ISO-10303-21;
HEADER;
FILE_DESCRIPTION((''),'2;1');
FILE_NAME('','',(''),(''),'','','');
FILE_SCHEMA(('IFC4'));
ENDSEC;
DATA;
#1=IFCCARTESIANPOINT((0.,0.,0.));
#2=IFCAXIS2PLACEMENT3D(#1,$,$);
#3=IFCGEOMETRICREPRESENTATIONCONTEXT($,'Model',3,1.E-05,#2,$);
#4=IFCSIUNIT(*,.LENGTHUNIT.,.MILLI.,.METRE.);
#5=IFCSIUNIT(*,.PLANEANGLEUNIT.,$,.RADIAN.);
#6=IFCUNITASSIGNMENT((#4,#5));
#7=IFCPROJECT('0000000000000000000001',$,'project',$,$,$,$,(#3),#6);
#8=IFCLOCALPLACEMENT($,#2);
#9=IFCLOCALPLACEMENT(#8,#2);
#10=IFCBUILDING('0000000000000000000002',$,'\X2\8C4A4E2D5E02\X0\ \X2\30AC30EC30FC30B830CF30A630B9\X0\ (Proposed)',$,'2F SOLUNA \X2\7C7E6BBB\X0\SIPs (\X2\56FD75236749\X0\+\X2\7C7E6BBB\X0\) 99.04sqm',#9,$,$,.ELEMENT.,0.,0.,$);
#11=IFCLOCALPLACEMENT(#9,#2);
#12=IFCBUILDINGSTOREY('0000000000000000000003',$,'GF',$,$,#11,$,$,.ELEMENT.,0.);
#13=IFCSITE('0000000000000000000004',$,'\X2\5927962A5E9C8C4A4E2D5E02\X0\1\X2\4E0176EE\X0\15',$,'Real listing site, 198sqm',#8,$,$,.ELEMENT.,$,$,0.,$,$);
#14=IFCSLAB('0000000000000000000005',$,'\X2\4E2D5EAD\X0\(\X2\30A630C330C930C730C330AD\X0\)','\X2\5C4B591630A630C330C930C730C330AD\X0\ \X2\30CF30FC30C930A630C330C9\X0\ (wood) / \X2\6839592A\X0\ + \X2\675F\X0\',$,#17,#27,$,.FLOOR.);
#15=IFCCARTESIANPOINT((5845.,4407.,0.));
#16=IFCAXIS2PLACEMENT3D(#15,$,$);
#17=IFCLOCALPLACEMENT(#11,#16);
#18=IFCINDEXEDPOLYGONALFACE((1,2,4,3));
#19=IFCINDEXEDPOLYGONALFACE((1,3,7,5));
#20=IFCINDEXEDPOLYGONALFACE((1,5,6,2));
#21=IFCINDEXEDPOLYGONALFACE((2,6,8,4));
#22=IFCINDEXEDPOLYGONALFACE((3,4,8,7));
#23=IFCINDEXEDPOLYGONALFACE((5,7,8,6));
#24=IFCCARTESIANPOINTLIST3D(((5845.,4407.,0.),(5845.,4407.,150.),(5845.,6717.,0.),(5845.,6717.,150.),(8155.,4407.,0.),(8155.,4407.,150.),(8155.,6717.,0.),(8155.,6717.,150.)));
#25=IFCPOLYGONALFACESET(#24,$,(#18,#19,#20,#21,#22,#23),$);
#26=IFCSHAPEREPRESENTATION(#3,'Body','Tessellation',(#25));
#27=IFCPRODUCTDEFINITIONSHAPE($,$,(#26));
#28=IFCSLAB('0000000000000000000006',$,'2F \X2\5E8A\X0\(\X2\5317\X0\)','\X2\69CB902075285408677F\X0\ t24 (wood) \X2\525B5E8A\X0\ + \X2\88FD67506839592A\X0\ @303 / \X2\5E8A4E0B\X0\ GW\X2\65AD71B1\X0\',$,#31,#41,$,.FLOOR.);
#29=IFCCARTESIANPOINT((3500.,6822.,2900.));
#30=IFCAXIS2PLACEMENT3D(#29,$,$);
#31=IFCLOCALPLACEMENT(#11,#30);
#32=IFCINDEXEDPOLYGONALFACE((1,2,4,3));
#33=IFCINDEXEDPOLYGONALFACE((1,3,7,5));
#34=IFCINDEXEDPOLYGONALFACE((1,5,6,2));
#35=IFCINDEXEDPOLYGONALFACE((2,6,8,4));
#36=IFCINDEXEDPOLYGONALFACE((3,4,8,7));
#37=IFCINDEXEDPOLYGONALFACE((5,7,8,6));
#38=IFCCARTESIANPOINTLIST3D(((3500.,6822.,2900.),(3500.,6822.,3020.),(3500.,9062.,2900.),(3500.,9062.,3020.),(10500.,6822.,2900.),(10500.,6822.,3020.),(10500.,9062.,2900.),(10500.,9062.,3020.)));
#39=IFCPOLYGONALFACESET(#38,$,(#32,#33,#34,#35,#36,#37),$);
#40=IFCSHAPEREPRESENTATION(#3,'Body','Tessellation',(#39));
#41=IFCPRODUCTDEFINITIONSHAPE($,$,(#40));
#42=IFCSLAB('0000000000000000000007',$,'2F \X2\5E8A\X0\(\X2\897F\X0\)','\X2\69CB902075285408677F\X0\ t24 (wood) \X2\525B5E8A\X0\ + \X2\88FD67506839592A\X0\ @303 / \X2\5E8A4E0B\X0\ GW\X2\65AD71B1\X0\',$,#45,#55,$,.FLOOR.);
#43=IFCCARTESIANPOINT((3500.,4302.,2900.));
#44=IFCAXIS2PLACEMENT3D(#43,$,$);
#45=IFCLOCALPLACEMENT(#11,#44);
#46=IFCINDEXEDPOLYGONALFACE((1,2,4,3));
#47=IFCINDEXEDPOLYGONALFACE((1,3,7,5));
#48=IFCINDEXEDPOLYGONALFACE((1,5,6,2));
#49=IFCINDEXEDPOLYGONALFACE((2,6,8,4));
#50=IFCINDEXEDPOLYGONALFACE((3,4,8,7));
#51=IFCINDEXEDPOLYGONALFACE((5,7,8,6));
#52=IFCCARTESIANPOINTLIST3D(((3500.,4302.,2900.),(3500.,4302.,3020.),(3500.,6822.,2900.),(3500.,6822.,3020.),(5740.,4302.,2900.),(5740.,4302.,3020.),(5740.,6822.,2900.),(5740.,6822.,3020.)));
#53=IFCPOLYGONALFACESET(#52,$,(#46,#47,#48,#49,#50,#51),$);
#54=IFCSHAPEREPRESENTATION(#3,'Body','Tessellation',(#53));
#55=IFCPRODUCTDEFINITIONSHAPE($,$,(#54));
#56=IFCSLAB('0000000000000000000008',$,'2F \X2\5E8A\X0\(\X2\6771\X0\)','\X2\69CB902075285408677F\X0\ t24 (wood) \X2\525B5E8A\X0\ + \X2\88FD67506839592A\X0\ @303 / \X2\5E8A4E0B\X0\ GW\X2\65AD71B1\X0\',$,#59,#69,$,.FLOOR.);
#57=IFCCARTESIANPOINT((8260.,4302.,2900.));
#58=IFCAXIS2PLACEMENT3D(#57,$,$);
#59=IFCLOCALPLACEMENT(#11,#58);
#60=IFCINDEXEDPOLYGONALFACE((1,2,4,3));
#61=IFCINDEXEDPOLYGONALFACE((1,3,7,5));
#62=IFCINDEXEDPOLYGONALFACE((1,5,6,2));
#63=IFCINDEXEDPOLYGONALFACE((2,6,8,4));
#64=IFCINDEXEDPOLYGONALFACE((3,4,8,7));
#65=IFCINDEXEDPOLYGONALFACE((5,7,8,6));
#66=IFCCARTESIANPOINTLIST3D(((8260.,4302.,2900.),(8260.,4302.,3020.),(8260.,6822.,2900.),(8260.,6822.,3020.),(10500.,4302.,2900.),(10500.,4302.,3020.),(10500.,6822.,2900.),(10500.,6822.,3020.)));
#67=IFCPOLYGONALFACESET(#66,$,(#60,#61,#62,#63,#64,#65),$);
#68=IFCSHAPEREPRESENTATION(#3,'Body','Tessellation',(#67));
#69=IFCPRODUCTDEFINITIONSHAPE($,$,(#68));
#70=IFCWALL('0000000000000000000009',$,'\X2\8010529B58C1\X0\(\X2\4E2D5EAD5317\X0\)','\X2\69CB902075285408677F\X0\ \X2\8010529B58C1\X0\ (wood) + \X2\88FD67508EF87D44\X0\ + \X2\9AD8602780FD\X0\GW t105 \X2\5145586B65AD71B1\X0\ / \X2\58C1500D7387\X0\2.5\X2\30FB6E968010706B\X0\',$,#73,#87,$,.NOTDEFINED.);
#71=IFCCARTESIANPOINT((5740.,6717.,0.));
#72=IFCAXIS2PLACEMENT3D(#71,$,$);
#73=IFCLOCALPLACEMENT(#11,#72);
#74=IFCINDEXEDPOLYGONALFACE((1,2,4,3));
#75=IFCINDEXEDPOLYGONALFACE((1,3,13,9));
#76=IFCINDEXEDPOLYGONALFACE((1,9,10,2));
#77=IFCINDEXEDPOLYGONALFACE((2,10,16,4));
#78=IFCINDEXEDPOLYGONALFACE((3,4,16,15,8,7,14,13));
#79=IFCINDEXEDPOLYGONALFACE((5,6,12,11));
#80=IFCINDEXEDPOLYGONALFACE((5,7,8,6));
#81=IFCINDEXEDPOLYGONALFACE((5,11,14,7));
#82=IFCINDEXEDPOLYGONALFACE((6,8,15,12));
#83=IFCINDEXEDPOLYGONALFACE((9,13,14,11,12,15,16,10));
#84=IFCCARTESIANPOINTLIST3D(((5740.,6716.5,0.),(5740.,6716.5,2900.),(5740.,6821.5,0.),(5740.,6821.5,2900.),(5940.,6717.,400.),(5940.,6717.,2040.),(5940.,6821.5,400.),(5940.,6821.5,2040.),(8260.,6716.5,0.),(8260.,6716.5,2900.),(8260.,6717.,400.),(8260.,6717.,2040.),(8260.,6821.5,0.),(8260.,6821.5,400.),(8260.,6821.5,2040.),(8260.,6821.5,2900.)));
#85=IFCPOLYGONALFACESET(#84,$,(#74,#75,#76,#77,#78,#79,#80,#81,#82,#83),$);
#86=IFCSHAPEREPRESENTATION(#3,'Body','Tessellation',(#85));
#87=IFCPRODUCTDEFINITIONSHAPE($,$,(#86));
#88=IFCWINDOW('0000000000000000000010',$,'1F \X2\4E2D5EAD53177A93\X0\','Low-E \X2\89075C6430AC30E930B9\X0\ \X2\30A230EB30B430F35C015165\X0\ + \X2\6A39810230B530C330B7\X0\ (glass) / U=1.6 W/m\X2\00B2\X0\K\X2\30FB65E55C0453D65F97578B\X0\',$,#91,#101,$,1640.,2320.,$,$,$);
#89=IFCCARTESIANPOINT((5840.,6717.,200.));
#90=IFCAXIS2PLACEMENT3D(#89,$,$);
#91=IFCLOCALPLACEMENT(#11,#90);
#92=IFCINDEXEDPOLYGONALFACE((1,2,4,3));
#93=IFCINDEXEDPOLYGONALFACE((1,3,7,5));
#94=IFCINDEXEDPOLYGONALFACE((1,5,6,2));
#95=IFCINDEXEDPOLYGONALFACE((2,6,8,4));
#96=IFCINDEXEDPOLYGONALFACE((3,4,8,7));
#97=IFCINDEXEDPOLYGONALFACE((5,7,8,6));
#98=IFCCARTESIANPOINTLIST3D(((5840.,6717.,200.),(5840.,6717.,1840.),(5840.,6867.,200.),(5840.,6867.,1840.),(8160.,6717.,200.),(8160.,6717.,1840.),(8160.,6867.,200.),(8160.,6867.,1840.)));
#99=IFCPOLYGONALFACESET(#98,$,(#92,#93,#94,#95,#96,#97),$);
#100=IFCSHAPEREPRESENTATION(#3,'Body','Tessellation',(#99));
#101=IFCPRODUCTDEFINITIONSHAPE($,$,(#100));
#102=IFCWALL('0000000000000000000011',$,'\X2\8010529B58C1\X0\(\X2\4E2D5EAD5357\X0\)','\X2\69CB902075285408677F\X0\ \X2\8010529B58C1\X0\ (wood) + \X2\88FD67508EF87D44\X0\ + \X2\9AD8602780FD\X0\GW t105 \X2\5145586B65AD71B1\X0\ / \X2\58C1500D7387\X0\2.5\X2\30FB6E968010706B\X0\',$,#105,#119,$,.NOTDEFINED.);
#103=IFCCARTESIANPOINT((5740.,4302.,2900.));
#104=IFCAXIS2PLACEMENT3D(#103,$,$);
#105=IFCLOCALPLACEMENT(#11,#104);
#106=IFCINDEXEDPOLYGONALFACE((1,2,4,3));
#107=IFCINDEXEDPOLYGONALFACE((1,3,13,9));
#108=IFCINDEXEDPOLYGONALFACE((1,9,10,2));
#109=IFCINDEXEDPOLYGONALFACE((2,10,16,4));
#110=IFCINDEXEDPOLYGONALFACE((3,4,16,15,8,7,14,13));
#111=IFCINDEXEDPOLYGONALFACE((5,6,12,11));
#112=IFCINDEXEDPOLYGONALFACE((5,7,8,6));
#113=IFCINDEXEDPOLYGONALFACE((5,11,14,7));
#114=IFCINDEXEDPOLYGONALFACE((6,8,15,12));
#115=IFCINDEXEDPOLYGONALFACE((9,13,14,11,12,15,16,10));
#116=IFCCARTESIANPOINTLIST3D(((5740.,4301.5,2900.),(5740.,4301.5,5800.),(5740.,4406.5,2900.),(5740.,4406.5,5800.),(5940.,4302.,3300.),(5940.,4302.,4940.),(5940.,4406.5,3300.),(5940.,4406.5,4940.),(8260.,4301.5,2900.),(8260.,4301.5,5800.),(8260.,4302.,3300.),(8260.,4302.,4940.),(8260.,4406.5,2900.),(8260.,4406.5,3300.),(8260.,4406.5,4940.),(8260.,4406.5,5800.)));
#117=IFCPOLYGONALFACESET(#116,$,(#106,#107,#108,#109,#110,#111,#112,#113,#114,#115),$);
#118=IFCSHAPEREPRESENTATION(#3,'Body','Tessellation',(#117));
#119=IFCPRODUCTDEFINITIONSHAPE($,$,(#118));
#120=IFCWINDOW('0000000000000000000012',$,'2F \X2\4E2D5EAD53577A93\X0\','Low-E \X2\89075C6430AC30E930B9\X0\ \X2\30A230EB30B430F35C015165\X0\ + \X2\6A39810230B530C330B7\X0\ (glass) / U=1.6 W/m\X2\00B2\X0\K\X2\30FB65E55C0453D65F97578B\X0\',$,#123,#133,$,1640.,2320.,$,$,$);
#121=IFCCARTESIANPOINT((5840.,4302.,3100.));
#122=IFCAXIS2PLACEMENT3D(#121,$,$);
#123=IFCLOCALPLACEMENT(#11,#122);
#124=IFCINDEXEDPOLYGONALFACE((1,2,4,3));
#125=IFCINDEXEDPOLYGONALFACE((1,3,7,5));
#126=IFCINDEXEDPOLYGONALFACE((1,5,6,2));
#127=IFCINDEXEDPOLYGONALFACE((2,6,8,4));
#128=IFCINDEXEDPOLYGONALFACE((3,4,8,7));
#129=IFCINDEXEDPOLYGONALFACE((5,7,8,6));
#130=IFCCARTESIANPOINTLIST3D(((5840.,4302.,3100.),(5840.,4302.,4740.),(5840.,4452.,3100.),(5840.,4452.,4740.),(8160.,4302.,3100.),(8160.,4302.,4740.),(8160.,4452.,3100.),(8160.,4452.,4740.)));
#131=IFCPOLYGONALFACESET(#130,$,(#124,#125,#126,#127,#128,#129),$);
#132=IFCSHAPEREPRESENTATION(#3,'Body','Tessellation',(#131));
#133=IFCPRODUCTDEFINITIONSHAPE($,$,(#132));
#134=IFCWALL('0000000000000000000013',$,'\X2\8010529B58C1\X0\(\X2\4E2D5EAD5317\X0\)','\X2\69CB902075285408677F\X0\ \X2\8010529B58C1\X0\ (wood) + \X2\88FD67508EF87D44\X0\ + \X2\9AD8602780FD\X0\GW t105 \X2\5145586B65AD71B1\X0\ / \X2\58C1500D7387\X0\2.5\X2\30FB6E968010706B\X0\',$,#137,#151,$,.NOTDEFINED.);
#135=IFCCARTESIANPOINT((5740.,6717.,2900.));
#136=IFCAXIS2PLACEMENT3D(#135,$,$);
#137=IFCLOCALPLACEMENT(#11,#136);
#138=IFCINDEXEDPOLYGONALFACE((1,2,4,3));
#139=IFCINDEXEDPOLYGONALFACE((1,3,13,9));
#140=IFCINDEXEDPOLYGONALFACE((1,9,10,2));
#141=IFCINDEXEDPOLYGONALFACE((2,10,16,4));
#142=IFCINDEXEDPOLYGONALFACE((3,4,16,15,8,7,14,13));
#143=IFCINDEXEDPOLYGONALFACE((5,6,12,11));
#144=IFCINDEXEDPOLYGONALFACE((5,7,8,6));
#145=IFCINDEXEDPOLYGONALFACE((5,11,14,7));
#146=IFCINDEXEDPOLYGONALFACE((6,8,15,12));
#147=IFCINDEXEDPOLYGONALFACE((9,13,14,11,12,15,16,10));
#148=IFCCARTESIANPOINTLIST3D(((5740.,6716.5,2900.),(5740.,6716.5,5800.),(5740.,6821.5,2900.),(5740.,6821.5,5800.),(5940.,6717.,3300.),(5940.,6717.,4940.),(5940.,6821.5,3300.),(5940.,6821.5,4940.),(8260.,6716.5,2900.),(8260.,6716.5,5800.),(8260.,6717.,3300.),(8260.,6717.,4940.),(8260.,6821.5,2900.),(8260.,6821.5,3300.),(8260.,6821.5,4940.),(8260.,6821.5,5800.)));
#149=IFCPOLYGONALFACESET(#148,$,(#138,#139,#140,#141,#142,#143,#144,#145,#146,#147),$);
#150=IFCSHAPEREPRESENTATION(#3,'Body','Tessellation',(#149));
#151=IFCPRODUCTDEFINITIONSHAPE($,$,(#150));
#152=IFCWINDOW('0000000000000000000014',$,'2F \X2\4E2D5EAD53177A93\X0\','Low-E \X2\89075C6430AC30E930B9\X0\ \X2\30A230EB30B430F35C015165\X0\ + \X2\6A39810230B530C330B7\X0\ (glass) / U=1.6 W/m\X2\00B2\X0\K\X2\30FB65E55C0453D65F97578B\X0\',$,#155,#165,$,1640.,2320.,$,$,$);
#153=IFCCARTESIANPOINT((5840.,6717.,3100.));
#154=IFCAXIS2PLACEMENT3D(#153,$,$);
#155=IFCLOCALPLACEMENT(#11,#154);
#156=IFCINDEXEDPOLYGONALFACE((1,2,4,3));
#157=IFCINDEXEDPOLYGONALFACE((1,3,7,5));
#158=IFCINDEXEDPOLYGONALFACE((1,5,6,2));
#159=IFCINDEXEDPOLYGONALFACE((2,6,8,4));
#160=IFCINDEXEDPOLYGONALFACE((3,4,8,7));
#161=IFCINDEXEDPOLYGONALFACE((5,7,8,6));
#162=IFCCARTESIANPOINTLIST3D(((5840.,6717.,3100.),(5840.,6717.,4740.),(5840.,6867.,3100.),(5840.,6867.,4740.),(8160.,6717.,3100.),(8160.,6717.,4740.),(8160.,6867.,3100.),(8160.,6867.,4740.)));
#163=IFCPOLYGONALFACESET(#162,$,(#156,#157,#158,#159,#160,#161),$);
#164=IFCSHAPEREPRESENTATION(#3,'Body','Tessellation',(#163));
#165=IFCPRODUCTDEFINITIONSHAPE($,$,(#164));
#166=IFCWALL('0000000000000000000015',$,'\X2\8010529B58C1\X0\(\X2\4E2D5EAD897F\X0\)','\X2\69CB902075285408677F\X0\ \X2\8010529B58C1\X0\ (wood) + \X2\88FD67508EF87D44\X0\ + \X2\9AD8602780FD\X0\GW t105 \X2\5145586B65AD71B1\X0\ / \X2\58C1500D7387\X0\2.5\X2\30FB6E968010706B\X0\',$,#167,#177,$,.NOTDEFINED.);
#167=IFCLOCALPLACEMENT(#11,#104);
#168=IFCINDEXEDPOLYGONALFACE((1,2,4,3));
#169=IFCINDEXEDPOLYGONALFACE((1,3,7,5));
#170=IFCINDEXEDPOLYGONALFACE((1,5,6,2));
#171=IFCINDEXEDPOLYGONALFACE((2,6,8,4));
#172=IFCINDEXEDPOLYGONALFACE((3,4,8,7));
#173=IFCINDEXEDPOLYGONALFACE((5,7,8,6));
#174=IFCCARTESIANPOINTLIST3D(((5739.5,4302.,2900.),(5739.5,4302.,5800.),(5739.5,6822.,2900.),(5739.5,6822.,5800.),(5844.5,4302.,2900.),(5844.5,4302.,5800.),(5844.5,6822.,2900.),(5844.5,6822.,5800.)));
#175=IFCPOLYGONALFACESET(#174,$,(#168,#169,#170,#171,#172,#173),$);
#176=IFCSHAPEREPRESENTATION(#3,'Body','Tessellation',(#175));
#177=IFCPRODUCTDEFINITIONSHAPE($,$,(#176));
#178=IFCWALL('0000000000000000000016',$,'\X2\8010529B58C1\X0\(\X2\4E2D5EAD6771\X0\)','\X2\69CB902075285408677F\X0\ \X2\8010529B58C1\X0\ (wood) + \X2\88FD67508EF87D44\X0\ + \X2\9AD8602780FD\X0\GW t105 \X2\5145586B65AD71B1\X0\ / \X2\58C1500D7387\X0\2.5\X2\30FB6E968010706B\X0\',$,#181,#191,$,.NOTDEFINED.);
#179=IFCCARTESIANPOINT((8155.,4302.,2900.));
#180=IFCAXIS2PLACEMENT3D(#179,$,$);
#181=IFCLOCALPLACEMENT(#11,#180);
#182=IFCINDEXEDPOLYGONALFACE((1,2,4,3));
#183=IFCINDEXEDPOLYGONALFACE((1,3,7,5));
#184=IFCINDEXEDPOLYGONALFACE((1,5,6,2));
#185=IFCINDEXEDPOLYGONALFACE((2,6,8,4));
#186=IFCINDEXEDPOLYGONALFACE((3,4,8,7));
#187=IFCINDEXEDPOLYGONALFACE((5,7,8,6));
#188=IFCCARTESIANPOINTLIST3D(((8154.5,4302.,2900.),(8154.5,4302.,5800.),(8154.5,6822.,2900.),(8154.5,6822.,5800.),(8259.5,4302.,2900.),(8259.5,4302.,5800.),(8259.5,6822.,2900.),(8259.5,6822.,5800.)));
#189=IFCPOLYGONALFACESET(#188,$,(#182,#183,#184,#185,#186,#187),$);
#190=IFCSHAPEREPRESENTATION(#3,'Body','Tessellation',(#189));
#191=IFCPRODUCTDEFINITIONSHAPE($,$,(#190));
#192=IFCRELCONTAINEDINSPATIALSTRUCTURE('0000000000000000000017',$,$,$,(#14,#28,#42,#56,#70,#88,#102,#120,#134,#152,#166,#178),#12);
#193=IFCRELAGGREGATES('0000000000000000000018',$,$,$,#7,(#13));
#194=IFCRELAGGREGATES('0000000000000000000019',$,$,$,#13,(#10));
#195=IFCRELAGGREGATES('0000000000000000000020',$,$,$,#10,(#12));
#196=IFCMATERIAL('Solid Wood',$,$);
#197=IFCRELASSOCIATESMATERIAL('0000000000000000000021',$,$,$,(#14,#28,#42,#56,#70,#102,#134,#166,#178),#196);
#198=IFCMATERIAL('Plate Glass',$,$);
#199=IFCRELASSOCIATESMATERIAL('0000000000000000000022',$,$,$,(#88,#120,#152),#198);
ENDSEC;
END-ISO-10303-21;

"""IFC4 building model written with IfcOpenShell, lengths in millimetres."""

from ifc_helpers import new_model, si_unit, frame, frame_2d, origin, place, context, project, spatial, rectangle, extrude, material, element, fill, save


model = new_model("IFC4")

# Units and contexts
model_context = context("Model", 3, precision=1e-05, world=origin())
ifc_project = project(units=[si_unit("LENGTHUNIT", "METRE", prefix="MILLI"), si_unit("PLANEANGLEUNIT", "RADIAN")], contexts=[model_context])

# Site, building, storey
site_placement = place(None, origin())
site = spatial("IfcSite", under=ifc_project, at=site_placement, Name="大阪府豊中市1丁目15", ObjectType="Real listing site, 198sqm", CompositionType="ELEMENT", RefElevation=0.0)
building_placement = place(site_placement, origin())
building = spatial("IfcBuilding", under=site, at=building_placement, Name="豊中市 ガレージハウス (Proposed)", ObjectType="2F SOLUNA 籾殻SIPs (国産杉+籾殻) 99.04sqm", CompositionType="ELEMENT", ElevationOfRefHeight=0.0, ElevationOfTerrain=0.0)
storey_placement = place(building_placement, origin())
storey = spatial("IfcBuildingStorey", under=building, at=storey_placement, Name="GF", CompositionType="ELEMENT", Elevation=0.0)

# Slabs
ifc_material_1 = material(Name="Solid Wood")
slab_1_placement = place(storey_placement, frame((5845.0, 4407.0, 0.0)))
element("IfcSlab", 1, at=slab_1_placement, inside=storey, material=ifc_material_1, Name="中庭(ウッドデッキ)", Description="屋外ウッドデッキ ハードウッド (wood) / 根太 + 束", PredefinedType="FLOOR", context=model_context, shape_type="SweptSolid", body=[
    extrude(rectangle(XDim=2310.0, YDim=2310.0, at=frame_2d((1155.0, 1155.0))), frame((5845.0, 4407.0, 0.0)), (0.0, 0.0, 1.0), 150.0),
])
slab_2_placement = place(storey_placement, frame((3500.0, 6822.0, 2900.0)))
element("IfcSlab", 2, at=slab_2_placement, inside=storey, material=ifc_material_1, Name="2F 床(北)", Description="構造用合板 t24 (wood) 剛床 + 製材根太 @303 / 床下 GW断熱", PredefinedType="FLOOR", context=model_context, shape_type="SweptSolid", body=[
    extrude(rectangle(XDim=7000.0, YDim=2240.0, at=frame_2d((3500.0, 1120.0))), frame((3500.0, 6822.0, 2900.0)), (0.0, 0.0, 1.0), 120.0),
])
slab_3_placement = place(storey_placement, frame((3500.0, 4302.0, 2900.0)))
element("IfcSlab", 3, at=slab_3_placement, inside=storey, material=ifc_material_1, Name="2F 床(西)", Description="構造用合板 t24 (wood) 剛床 + 製材根太 @303 / 床下 GW断熱", PredefinedType="FLOOR", context=model_context, shape_type="SweptSolid", body=[
    extrude(rectangle(XDim=2240.0, YDim=2520.0, at=frame_2d((1120.0, 1260.0))), frame((3500.0, 4302.0, 2900.0)), (0.0, 0.0, 1.0), 120.0),
])
slab_4_placement = place(storey_placement, frame((8260.0, 4302.0, 2900.0)))
element("IfcSlab", 4, at=slab_4_placement, inside=storey, material=ifc_material_1, Name="2F 床(東)", Description="構造用合板 t24 (wood) 剛床 + 製材根太 @303 / 床下 GW断熱", PredefinedType="FLOOR", context=model_context, shape_type="SweptSolid", body=[
    extrude(rectangle(XDim=2240.0, YDim=2520.0, at=frame_2d((1120.0, 1260.0))), frame((8260.0, 4302.0, 2900.0)), (0.0, 0.0, 1.0), 120.0),
])

# Wall, opening, window
wall_1_placement = place(storey_placement, frame((5740.0, 6717.0, 0.0)))
wall_1 = element("IfcWall", 5, at=wall_1_placement, inside=storey, material=ifc_material_1, Name="耐力壁(中庭北)", Description="構造用合板 耐力壁 (wood) + 製材軸組 + 高性能GW t105 充填断熱 / 壁倍率2.5・準耐火", PredefinedType="NOTDEFINED", context=model_context, shape_type="SweptSolid", body=[
    extrude(rectangle(XDim=2520.0, YDim=105.0, at=frame_2d((1260.0, 52.0))), frame((5740.0, 6717.0, 0.0)), (0.0, 0.0, 1.0), 2900.0),
])
opening_1_placement = place(storey_placement, frame((5840.0, 6717.0, 200.0)))
opening_1 = element("IfcOpeningElement", 6, at=opening_1_placement, cuts=wall_1, PredefinedType="NOTDEFINED", context=model_context, shape_type="SweptSolid", body=[
    extrude(rectangle(XDim=2320.0, YDim=150.0, at=frame_2d((1160.0, 75.0))), frame((5840.0, 6717.0, 200.0)), (0.0, 0.0, 1.0), 1640.0),
])
ifc_material_2 = material(Name="Plate Glass")
window_1_placement = place(storey_placement, frame((5840.0, 6717.0, 200.0)))
window_1 = element("IfcWindow", 7, at=window_1_placement, inside=storey, material=ifc_material_2, Name="1F 中庭北窓", Description="Low-E 複層ガラス アルゴン封入 + 樹脂サッシ (glass) / U=1.6 W/m²K・日射取得型", OverallHeight=1640.0, OverallWidth=2320.0, context=model_context, shape_type="SweptSolid", body=[
    extrude(rectangle(XDim=2320.0, YDim=150.0, at=frame_2d((1160.0, 75.0))), frame((5840.0, 6717.0, 200.0)), (0.0, 0.0, 1.0), 1640.0),
])
fill(opening_1, window_1)

# Walls, openings, windows
wall_2_placement = place(storey_placement, frame((5740.0, 4302.0, 2900.0)))
wall_2 = element("IfcWall", 8, at=wall_2_placement, inside=storey, material=ifc_material_1, Name="耐力壁(中庭南)", Description="構造用合板 耐力壁 (wood) + 製材軸組 + 高性能GW t105 充填断熱 / 壁倍率2.5・準耐火", PredefinedType="NOTDEFINED", context=model_context, shape_type="SweptSolid", body=[
    extrude(rectangle(XDim=2520.0, YDim=105.0, at=frame_2d((1260.0, 52.0))), frame((5740.0, 4302.0, 2900.0)), (0.0, 0.0, 1.0), 2900.0),
])
opening_2_placement = place(storey_placement, frame((5840.0, 4302.0, 3100.0)))
opening_2 = element("IfcOpeningElement", 9, at=opening_2_placement, cuts=wall_2, PredefinedType="NOTDEFINED", context=model_context, shape_type="SweptSolid", body=[
    extrude(rectangle(XDim=2320.0, YDim=150.0, at=frame_2d((1160.0, 75.0))), frame((5840.0, 4302.0, 3100.0)), (0.0, 0.0, 1.0), 1640.0),
])
window_2_placement = place(storey_placement, frame((5840.0, 4302.0, 3100.0)))
window_2 = element("IfcWindow", 10, at=window_2_placement, inside=storey, material=ifc_material_2, Name="2F 中庭南窓", Description="Low-E 複層ガラス アルゴン封入 + 樹脂サッシ (glass) / U=1.6 W/m²K・日射取得型", OverallHeight=1640.0, OverallWidth=2320.0, context=model_context, shape_type="SweptSolid", body=[
    extrude(rectangle(XDim=2320.0, YDim=150.0, at=frame_2d((1160.0, 75.0))), frame((5840.0, 4302.0, 3100.0)), (0.0, 0.0, 1.0), 1640.0),
])
fill(opening_2, window_2)
wall_3_placement = place(storey_placement, frame((5740.0, 6717.0, 2900.0)))
wall_3 = element("IfcWall", 11, at=wall_3_placement, inside=storey, material=ifc_material_1, Name="耐力壁(中庭北)", Description="構造用合板 耐力壁 (wood) + 製材軸組 + 高性能GW t105 充填断熱 / 壁倍率2.5・準耐火", PredefinedType="NOTDEFINED", context=model_context, shape_type="SweptSolid", body=[
    extrude(rectangle(XDim=2520.0, YDim=105.0, at=frame_2d((1260.0, 52.0))), frame((5740.0, 6717.0, 2900.0)), (0.0, 0.0, 1.0), 2900.0),
])
opening_3_placement = place(storey_placement, frame((5840.0, 6717.0, 3100.0)))
opening_3 = element("IfcOpeningElement", 12, at=opening_3_placement, cuts=wall_3, PredefinedType="NOTDEFINED", context=model_context, shape_type="SweptSolid", body=[
    extrude(rectangle(XDim=2320.0, YDim=150.0, at=frame_2d((1160.0, 75.0))), frame((5840.0, 6717.0, 3100.0)), (0.0, 0.0, 1.0), 1640.0),
])
window_3_placement = place(storey_placement, frame((5840.0, 6717.0, 3100.0)))
window_3 = element("IfcWindow", 13, at=window_3_placement, inside=storey, material=ifc_material_2, Name="2F 中庭北窓", Description="Low-E 複層ガラス アルゴン封入 + 樹脂サッシ (glass) / U=1.6 W/m²K・日射取得型", OverallHeight=1640.0, OverallWidth=2320.0, context=model_context, shape_type="SweptSolid", body=[
    extrude(rectangle(XDim=2320.0, YDim=150.0, at=frame_2d((1160.0, 75.0))), frame((5840.0, 6717.0, 3100.0)), (0.0, 0.0, 1.0), 1640.0),
])
fill(opening_3, window_3)

# Walls
wall_4_placement = place(storey_placement, frame((5740.0, 4302.0, 2900.0)))
element("IfcWall", 14, at=wall_4_placement, inside=storey, material=ifc_material_1, Name="耐力壁(中庭西)", Description="構造用合板 耐力壁 (wood) + 製材軸組 + 高性能GW t105 充填断熱 / 壁倍率2.5・準耐火", PredefinedType="NOTDEFINED", context=model_context, shape_type="SweptSolid", body=[
    extrude(rectangle(XDim=105.0, YDim=2520.0, at=frame_2d((52.0, 1260.0))), frame((5740.0, 4302.0, 2900.0)), (0.0, 0.0, 1.0), 2900.0),
])
wall_5_placement = place(storey_placement, frame((8155.0, 4302.0, 2900.0)))
element("IfcWall", 15, at=wall_5_placement, inside=storey, material=ifc_material_1, Name="耐力壁(中庭東)", Description="構造用合板 耐力壁 (wood) + 製材軸組 + 高性能GW t105 充填断熱 / 壁倍率2.5・準耐火", PredefinedType="NOTDEFINED", context=model_context, shape_type="SweptSolid", body=[
    extrude(rectangle(XDim=105.0, YDim=2520.0, at=frame_2d((52.0, 1260.0))), frame((8155.0, 4302.0, 2900.0)), (0.0, 0.0, 1.0), 2900.0),
])

save(model, "model.ifc")
